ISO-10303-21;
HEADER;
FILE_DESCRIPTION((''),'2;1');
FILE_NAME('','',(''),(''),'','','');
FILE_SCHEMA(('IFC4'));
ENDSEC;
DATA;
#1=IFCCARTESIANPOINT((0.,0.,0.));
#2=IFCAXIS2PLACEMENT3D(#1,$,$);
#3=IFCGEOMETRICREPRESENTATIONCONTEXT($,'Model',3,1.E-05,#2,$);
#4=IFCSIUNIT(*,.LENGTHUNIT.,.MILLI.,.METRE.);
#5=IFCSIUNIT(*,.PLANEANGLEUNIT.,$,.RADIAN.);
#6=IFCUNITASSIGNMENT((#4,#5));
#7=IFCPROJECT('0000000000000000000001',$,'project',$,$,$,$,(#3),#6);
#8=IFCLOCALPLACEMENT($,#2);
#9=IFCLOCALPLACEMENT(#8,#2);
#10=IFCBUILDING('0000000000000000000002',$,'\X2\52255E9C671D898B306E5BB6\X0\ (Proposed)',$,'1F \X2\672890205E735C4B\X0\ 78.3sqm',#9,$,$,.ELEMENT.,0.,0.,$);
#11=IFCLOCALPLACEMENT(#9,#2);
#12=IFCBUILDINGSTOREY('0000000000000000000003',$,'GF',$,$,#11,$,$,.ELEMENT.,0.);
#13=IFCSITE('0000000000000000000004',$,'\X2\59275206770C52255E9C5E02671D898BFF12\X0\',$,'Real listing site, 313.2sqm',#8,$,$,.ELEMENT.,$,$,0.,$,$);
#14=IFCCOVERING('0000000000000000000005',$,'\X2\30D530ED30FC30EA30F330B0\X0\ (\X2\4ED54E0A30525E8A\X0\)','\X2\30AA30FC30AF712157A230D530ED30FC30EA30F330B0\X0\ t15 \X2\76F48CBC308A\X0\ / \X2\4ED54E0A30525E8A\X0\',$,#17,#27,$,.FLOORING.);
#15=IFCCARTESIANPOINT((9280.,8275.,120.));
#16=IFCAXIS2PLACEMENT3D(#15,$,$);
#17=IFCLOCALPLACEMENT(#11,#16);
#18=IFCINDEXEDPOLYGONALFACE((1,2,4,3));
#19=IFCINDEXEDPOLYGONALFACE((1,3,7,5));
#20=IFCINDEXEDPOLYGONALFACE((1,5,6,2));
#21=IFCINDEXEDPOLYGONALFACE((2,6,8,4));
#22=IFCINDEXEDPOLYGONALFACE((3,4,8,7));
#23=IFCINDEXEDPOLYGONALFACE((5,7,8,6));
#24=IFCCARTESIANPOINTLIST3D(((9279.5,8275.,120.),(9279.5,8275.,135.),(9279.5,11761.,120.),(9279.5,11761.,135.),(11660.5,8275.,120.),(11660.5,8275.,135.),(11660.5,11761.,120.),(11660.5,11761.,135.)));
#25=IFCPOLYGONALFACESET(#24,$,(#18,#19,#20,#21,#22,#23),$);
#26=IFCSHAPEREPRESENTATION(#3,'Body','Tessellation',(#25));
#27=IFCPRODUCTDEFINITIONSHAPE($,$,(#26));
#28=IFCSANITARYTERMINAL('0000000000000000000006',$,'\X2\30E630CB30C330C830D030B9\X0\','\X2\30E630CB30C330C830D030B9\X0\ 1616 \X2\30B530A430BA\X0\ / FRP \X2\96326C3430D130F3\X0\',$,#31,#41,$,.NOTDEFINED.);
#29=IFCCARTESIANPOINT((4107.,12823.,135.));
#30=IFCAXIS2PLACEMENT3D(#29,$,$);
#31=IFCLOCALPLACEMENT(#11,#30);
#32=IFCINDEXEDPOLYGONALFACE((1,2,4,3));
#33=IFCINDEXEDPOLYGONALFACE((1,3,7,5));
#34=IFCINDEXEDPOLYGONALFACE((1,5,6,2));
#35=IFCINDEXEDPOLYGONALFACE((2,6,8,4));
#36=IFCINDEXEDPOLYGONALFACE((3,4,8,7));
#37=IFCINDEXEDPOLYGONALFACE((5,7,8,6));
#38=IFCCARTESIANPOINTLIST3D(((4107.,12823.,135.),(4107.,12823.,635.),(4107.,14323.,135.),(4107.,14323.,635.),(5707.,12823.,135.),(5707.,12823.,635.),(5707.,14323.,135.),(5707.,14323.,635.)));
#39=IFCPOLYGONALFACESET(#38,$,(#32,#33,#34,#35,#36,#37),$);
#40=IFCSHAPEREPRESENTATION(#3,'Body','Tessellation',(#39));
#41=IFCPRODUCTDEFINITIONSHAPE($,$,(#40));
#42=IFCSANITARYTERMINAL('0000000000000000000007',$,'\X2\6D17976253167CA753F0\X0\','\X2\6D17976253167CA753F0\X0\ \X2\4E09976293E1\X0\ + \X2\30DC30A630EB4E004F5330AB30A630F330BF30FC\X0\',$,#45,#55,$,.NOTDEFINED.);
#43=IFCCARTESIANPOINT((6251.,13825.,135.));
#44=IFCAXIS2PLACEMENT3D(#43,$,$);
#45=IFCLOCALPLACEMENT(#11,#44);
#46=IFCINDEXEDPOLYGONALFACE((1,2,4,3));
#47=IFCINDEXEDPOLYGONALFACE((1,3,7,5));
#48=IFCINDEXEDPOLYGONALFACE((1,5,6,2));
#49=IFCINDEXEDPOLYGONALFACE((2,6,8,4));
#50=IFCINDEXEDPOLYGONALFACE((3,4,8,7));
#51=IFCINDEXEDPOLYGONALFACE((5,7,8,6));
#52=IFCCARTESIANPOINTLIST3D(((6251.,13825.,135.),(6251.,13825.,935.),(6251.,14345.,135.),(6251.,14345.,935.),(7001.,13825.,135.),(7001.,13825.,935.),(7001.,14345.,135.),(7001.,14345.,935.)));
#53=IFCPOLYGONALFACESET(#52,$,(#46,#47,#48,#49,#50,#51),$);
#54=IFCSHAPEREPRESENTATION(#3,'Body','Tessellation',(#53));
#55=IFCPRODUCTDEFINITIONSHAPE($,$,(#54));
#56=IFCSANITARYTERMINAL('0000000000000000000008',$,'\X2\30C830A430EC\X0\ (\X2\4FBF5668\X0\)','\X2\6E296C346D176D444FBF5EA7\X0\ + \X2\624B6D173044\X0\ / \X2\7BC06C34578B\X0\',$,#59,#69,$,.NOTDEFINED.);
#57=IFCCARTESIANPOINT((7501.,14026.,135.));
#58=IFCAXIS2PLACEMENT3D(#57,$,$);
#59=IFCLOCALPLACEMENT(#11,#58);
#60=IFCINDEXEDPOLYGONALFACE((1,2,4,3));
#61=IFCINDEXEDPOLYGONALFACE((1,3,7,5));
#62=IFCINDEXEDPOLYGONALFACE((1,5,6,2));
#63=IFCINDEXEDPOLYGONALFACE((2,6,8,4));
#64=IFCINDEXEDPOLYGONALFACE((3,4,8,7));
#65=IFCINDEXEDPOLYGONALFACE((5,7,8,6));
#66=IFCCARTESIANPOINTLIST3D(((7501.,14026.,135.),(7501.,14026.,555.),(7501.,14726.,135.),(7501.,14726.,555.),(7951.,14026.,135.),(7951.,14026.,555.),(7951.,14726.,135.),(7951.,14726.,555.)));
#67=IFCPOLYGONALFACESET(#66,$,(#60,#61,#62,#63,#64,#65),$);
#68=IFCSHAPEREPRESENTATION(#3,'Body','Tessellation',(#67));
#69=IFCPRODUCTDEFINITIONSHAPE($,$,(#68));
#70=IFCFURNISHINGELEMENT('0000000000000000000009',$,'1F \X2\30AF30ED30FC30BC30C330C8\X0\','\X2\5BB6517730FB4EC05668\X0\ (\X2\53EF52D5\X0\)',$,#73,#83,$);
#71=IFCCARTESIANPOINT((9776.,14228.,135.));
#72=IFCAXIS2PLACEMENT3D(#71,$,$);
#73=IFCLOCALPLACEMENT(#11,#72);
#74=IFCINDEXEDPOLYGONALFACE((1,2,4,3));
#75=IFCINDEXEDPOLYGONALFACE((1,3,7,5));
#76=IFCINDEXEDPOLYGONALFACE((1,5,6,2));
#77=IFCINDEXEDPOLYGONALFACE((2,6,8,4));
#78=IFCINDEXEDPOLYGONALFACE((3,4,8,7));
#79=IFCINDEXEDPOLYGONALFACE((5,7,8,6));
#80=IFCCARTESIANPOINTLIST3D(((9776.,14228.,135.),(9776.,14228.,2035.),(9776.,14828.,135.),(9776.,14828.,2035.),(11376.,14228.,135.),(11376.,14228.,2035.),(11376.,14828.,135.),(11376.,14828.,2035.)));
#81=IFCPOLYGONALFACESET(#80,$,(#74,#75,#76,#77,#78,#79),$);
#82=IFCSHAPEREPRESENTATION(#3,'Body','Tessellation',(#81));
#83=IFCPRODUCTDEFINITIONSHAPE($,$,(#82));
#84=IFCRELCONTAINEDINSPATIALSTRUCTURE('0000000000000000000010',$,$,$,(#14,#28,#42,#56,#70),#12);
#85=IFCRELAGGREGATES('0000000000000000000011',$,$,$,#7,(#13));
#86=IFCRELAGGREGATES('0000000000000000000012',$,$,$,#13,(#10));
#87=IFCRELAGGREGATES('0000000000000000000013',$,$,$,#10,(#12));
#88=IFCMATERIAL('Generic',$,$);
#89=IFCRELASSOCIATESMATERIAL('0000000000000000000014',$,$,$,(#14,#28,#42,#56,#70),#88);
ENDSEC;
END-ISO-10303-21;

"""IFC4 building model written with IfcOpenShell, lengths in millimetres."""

from ifc_helpers import new_model, si_unit, frame, frame_2d, origin, place, context, project, spatial, rectangle, extrude, material, element, save


model = new_model("IFC4")

# Units and contexts
model_context = context("Model", 3, precision=1e-05, world=origin())
ifc_project = project(units=[si_unit("LENGTHUNIT", "METRE", prefix="MILLI"), si_unit("PLANEANGLEUNIT", "RADIAN")], contexts=[model_context])

# Site, building, storey
site_placement = place(None, origin())
site = spatial("IfcSite", under=ifc_project, at=site_placement, Name="大分県別府市朝見２", ObjectType="Real listing site, 313.2sqm", CompositionType="ELEMENT", RefElevation=0.0)
building_placement = place(site_placement, origin())
building = spatial("IfcBuilding", under=site, at=building_placement, Name="別府朝見の家 (Proposed)", ObjectType="1F 木造平屋 78.3sqm", CompositionType="ELEMENT", ElevationOfRefHeight=0.0, ElevationOfTerrain=0.0)
storey_placement = place(building_placement, origin())
storey = spatial("IfcBuildingStorey", under=building, at=storey_placement, Name="GF", CompositionType="ELEMENT", Elevation=0.0)

# Covering
ifc_material_1 = material(Name="Generic")
covering_1_placement = place(storey_placement, frame((9280.0, 8275.0, 120.0)))
element("IfcCovering", 1, at=covering_1_placement, inside=storey, material=ifc_material_1, Name="フローリング (仕上げ床)", Description="オーク無垢フローリング t15 直貼り / 仕上げ床", PredefinedType="FLOORING", context=model_context, shape_type="SweptSolid", body=[
    extrude(rectangle(XDim=2381.0, YDim=3486.0, at=frame_2d((1190.0, 1743.0))), frame((9280.0, 8275.0, 120.0)), (0.0, 0.0, 1.0), 15.0),
])

# Sanitary terminals
sanitary_terminal_1_placement = place(storey_placement, frame((4107.0, 12823.0, 135.0)))
element("IfcSanitaryTerminal", 2, at=sanitary_terminal_1_placement, inside=storey, material=ifc_material_1, Name="ユニットバス", Description="ユニットバス 1616 サイズ / FRP 防水パン", PredefinedType="NOTDEFINED", context=model_context, shape_type="SweptSolid", body=[
    extrude(rectangle(XDim=1600.0, YDim=1500.0, at=frame_2d((800.0, 750.0))), frame((4107.0, 12823.0, 135.0)), (0.0, 0.0, 1.0), 500.0),
])
sanitary_terminal_2_placement = place(storey_placement, frame((6251.0, 13825.0, 135.0)))
element("IfcSanitaryTerminal", 3, at=sanitary_terminal_2_placement, inside=storey, material=ifc_material_1, Name="洗面化粧台", Description="洗面化粧台 三面鏡 + ボウル一体カウンター", PredefinedType="NOTDEFINED", context=model_context, shape_type="SweptSolid", body=[
    extrude(rectangle(XDim=750.0, YDim=520.0, at=frame_2d((375.0, 260.0))), frame((6251.0, 13825.0, 135.0)), (0.0, 0.0, 1.0), 800.0),
])
sanitary_terminal_3_placement = place(storey_placement, frame((7501.0, 14026.0, 135.0)))
element("IfcSanitaryTerminal", 4, at=sanitary_terminal_3_placement, inside=storey, material=ifc_material_1, Name="トイレ (便器)", Description="温水洗浄便座 + 手洗い / 節水型", PredefinedType="NOTDEFINED", context=model_context, shape_type="SweptSolid", body=[
    extrude(rectangle(XDim=450.0, YDim=700.0, at=frame_2d((225.0, 350.0))), frame((7501.0, 14026.0, 135.0)), (0.0, 0.0, 1.0), 420.0),
])

# Furnishing element
furnishing_placement = place(storey_placement, frame((9776.0, 14228.0, 135.0)))
element("IfcFurnishingElement", 5, at=furnishing_placement, inside=storey, material=ifc_material_1, Name="1F クローゼット", Description="家具・什器 (可動)", context=model_context, shape_type="SweptSolid", body=[
    extrude(rectangle(XDim=1600.0, YDim=600.0, at=frame_2d((800.0, 300.0))), frame((9776.0, 14228.0, 135.0)), (0.0, 0.0, 1.0), 1900.0),
])

save(model, "model.ifc")
